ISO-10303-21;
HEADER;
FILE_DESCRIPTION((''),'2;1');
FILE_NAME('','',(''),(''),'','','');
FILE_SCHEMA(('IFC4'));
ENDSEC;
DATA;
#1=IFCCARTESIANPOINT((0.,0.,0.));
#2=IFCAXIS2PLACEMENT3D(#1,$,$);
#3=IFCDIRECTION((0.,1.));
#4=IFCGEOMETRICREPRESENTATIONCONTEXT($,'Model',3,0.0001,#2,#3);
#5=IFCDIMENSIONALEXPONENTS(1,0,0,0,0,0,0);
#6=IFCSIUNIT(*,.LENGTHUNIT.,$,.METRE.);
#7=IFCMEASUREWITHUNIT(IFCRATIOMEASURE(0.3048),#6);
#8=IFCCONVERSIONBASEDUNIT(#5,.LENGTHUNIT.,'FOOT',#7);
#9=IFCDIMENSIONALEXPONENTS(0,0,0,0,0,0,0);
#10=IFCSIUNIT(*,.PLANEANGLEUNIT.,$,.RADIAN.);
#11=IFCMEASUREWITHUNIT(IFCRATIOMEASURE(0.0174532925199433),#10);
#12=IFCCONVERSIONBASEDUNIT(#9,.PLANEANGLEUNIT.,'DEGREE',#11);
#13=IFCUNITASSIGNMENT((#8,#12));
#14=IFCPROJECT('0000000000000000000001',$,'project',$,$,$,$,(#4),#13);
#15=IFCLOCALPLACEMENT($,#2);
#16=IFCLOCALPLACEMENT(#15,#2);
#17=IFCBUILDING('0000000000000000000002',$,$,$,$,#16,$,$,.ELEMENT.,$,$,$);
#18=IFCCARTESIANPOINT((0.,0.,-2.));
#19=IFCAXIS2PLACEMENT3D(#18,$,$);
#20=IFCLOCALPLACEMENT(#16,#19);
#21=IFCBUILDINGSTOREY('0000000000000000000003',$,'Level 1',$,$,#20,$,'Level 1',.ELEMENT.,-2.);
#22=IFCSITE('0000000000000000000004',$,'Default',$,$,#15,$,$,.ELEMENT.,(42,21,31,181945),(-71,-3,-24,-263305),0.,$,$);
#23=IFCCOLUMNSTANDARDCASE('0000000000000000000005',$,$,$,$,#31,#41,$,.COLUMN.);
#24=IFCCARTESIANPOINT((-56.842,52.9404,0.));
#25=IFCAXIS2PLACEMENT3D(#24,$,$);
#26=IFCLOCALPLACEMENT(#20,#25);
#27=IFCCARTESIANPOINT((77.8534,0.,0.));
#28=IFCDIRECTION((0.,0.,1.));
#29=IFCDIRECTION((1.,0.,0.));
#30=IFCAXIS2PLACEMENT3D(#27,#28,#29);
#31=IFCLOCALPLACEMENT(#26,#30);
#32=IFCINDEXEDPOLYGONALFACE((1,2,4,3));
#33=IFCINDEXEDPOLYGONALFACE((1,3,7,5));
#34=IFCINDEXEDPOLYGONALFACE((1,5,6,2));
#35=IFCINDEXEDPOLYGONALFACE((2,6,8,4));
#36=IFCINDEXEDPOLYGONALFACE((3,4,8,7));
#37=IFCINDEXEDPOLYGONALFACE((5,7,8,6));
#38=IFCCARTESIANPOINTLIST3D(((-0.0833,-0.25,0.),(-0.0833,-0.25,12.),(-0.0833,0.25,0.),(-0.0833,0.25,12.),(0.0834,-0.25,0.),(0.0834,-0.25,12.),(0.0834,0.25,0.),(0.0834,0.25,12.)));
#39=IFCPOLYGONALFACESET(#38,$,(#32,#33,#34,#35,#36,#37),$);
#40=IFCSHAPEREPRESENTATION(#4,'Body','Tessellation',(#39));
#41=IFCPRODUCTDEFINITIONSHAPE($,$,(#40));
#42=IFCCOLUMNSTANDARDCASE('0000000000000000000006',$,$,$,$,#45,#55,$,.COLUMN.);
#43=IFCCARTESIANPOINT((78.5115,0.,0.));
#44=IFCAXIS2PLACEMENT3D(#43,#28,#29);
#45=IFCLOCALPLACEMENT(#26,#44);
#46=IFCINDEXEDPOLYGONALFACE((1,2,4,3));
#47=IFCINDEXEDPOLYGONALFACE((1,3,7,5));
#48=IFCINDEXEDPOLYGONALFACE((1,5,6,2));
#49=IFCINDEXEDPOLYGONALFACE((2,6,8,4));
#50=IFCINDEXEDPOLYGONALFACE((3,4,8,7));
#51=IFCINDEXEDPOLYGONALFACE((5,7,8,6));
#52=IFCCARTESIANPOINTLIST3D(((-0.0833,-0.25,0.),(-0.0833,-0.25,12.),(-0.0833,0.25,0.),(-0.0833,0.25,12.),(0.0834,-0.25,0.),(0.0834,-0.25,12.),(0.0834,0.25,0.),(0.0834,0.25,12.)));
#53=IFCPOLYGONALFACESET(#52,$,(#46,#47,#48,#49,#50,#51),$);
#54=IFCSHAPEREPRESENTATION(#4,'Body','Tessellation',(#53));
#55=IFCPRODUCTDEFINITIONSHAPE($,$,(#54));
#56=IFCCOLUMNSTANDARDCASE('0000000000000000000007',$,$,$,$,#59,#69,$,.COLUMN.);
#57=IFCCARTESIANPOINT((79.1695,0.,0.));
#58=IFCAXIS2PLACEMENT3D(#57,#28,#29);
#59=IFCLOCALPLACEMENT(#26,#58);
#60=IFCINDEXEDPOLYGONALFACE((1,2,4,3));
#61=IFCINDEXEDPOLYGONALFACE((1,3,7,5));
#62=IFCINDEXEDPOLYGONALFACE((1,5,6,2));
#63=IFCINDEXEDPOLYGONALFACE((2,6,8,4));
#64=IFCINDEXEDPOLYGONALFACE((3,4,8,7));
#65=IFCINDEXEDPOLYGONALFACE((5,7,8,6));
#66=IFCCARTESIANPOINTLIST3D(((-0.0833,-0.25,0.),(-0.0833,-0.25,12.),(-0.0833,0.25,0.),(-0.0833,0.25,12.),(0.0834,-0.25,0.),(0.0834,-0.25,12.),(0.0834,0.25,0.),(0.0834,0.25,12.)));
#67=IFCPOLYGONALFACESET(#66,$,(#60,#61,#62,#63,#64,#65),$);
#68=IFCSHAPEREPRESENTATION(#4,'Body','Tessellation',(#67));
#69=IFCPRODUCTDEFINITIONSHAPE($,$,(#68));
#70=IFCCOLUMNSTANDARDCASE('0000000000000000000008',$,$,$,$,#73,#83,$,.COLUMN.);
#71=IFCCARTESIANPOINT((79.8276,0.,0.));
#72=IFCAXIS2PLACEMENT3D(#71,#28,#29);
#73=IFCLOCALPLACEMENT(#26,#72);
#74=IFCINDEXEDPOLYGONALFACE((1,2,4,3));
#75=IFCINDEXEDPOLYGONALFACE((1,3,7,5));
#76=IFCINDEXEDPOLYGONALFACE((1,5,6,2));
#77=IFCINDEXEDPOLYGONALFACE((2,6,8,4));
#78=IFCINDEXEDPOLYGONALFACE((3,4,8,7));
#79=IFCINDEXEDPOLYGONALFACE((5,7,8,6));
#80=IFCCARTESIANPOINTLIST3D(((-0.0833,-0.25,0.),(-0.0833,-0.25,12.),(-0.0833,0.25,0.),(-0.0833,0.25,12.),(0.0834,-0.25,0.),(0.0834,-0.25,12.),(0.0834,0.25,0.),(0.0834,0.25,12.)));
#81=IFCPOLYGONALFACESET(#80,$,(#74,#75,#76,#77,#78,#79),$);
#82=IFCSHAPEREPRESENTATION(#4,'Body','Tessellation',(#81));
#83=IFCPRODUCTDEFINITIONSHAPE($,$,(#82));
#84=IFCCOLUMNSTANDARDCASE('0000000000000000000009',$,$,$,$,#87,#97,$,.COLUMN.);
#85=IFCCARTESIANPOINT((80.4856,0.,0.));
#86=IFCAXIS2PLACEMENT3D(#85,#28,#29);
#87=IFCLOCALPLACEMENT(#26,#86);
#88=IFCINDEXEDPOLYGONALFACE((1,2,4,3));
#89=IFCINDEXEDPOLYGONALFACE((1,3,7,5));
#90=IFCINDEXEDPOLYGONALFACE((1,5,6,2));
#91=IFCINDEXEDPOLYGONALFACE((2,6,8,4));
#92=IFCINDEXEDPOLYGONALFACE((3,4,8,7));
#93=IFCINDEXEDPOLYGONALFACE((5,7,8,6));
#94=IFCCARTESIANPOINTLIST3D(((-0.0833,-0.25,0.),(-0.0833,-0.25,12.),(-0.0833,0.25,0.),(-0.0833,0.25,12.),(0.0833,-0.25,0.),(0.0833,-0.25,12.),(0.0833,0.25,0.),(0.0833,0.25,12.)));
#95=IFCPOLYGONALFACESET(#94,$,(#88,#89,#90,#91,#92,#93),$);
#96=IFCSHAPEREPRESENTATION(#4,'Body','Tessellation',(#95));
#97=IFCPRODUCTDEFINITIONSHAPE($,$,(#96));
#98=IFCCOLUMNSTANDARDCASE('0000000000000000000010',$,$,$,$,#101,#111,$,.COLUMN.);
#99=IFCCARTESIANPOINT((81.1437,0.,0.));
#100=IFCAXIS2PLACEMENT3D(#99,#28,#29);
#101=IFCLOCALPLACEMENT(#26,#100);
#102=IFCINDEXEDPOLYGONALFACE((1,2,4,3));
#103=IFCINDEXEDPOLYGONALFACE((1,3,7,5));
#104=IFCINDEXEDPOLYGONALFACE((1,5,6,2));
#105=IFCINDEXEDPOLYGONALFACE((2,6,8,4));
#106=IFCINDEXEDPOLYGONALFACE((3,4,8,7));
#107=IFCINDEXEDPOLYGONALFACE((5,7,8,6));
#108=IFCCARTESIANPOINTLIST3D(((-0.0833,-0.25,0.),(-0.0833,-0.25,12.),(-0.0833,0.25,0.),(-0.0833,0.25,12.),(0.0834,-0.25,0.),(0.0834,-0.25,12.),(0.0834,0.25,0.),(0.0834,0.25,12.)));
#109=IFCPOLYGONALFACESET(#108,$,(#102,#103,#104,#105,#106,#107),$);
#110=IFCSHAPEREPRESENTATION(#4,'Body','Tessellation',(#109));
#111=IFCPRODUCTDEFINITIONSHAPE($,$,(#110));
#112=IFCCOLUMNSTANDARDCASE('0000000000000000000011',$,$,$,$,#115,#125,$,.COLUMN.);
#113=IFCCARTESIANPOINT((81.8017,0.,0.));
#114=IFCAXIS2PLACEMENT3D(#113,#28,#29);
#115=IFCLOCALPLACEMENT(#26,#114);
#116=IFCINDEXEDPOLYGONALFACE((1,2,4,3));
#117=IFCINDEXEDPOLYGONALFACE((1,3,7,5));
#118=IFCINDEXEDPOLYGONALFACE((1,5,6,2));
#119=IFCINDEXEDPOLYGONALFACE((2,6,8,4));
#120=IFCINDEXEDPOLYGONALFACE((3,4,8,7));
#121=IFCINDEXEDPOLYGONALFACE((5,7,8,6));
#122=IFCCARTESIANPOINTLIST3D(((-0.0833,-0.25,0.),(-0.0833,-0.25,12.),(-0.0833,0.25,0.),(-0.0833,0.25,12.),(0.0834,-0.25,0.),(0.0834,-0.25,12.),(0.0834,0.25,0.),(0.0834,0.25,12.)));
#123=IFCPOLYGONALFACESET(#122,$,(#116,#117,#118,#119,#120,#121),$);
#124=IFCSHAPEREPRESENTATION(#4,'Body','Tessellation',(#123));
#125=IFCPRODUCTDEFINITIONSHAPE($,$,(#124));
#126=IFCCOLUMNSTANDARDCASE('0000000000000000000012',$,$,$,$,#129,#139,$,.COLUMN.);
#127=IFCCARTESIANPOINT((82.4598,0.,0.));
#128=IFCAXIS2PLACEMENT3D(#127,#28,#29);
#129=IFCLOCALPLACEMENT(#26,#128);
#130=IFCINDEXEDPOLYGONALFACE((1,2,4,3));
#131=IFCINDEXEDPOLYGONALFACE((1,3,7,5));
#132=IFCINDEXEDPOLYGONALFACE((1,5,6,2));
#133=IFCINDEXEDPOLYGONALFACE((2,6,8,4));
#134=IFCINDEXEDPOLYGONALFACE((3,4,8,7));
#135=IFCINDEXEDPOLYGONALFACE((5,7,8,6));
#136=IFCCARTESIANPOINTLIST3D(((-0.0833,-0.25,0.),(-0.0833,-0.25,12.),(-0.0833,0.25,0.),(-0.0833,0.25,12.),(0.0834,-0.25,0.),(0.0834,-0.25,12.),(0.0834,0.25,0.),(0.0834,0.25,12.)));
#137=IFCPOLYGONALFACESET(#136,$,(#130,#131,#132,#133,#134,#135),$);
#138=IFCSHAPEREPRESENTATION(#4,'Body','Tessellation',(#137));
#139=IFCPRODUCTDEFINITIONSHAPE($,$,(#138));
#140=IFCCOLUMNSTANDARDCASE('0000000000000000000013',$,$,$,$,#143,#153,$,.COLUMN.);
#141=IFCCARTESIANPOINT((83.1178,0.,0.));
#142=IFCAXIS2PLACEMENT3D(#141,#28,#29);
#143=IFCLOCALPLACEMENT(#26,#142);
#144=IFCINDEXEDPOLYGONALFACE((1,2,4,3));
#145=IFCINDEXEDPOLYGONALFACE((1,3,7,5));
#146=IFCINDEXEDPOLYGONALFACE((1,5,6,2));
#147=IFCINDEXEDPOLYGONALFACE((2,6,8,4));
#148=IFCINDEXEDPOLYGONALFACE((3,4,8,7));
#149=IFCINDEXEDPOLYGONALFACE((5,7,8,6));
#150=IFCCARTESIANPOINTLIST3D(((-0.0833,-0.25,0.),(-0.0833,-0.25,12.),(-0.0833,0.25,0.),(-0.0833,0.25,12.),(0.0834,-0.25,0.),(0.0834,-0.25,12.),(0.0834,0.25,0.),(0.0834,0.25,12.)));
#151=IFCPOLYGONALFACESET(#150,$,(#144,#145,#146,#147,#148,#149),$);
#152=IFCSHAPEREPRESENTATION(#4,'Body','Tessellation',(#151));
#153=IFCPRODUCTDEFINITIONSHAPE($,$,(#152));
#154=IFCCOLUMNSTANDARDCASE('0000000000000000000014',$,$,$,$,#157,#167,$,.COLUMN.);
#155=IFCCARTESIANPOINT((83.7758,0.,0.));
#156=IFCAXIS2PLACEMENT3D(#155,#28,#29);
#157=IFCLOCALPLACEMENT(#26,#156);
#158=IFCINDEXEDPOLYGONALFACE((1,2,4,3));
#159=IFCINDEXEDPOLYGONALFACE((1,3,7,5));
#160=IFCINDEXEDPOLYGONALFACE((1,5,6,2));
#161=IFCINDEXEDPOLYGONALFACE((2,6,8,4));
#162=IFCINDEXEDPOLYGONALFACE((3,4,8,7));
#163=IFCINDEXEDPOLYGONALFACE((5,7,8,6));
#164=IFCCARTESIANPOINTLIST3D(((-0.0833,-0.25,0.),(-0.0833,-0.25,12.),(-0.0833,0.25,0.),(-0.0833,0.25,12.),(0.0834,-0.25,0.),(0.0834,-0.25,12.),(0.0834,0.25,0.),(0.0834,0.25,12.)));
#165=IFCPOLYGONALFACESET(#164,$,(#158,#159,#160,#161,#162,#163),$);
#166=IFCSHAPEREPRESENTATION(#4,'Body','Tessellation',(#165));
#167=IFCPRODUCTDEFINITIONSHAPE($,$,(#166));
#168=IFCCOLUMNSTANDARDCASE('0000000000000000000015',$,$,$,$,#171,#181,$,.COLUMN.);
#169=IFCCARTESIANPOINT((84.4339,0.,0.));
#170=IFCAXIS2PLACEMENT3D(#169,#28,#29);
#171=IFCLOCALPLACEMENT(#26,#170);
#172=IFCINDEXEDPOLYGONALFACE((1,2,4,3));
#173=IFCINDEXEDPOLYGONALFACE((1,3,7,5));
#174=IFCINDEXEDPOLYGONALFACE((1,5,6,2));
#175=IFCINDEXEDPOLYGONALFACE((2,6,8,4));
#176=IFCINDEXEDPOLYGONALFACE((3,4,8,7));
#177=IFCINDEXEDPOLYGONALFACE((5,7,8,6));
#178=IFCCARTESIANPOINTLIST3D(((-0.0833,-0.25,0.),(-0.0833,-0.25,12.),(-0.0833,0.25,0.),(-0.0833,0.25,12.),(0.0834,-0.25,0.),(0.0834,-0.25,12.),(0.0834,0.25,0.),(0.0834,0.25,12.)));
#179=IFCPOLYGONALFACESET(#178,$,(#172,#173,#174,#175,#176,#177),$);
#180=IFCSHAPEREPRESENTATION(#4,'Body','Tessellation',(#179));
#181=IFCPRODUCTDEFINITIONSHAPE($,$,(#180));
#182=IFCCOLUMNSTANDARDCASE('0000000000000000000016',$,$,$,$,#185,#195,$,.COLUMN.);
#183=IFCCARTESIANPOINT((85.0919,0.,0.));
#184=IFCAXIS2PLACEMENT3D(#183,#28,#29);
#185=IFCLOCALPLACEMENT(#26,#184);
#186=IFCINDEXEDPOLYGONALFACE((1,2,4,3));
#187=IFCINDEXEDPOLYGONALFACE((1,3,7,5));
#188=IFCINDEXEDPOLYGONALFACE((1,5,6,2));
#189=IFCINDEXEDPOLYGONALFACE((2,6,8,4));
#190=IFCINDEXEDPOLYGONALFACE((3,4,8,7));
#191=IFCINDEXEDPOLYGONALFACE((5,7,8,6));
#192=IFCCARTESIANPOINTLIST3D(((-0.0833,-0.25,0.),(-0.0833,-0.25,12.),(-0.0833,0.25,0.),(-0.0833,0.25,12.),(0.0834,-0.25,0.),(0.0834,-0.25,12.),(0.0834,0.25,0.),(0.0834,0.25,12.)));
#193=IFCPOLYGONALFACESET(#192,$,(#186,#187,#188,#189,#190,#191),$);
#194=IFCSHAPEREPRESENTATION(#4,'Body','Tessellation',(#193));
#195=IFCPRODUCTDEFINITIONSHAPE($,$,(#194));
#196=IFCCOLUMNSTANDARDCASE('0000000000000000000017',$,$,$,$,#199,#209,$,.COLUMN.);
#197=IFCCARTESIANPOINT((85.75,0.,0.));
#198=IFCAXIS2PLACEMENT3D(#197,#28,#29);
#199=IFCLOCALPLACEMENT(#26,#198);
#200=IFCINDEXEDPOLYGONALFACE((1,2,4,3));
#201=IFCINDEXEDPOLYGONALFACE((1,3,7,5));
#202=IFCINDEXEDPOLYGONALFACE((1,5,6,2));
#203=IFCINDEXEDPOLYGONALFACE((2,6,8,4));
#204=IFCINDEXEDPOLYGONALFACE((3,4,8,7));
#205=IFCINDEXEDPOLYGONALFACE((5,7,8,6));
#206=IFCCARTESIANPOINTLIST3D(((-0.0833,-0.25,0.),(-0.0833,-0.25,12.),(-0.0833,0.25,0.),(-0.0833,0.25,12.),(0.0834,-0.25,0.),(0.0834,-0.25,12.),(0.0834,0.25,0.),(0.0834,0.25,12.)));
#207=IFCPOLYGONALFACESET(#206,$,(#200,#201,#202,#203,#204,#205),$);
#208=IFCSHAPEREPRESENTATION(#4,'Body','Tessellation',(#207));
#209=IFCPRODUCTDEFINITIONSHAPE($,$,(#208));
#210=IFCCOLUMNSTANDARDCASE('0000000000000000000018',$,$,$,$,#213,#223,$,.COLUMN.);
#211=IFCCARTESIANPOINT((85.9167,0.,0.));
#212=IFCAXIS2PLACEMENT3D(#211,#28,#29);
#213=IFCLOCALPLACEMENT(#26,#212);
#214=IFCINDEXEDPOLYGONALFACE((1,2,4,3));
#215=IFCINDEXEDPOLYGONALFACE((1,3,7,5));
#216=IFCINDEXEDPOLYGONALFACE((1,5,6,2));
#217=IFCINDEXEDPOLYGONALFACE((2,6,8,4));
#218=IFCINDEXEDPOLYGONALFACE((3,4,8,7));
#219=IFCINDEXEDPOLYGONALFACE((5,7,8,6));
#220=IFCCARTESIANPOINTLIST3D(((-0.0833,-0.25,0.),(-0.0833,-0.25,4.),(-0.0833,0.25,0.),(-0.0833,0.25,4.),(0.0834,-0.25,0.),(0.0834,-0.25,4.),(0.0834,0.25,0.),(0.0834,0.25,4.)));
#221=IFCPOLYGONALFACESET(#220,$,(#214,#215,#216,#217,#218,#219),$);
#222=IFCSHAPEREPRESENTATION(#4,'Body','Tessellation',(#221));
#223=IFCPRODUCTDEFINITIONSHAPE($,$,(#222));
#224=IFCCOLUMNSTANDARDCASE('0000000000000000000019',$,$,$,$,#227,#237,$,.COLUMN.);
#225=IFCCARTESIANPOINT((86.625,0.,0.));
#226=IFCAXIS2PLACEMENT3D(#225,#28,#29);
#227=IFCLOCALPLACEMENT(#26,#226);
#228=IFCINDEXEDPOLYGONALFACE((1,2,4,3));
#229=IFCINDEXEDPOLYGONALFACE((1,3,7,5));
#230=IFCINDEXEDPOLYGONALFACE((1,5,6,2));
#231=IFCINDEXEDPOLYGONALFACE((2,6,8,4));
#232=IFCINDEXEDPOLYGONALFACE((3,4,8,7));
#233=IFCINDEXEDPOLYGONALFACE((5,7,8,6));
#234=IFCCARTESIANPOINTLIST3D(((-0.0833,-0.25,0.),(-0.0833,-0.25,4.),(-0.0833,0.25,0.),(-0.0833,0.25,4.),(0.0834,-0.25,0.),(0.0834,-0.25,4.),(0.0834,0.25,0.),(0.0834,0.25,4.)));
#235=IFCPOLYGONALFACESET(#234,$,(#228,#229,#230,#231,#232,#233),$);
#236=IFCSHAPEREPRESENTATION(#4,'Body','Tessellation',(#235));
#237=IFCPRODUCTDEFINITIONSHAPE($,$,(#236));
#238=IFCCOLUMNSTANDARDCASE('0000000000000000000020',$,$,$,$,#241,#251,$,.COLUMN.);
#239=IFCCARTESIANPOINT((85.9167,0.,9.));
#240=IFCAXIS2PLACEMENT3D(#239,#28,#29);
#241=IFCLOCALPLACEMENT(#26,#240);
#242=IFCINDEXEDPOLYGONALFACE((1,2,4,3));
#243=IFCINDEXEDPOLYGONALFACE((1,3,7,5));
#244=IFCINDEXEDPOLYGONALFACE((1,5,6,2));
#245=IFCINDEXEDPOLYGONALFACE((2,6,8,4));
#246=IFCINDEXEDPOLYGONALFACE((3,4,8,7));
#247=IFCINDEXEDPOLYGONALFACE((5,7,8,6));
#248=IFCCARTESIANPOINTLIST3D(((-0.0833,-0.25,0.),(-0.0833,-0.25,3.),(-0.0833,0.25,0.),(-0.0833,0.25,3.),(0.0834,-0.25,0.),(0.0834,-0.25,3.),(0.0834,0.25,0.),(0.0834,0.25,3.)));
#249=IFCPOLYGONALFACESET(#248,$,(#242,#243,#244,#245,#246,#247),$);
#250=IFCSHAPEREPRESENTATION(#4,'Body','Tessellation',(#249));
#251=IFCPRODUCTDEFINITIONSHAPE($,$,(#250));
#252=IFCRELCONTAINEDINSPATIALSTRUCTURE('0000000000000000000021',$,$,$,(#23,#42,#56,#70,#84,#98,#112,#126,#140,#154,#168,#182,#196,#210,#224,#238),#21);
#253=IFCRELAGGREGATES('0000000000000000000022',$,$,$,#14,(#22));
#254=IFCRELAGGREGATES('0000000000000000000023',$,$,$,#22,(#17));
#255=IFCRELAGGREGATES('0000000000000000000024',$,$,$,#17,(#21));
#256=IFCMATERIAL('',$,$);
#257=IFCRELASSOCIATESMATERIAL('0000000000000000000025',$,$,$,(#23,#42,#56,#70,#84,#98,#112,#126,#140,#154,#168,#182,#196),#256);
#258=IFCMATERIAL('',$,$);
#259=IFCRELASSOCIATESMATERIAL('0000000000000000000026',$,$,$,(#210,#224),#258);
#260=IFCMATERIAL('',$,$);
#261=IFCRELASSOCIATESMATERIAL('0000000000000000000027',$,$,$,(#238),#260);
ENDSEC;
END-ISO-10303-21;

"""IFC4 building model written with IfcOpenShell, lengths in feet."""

from ifc_helpers import new_model, entity, si_unit, converted_unit, direction, frame, origin, place, context, project, spatial, rectangle, extrude, material, element, save


model = new_model("IFC4")

# Units and contexts
model_context = context("Model", 3, precision=0.0001, world=origin(), true_north=direction((0.0, 1.0)))
ifc_project = project(units=[converted_unit("LENGTHUNIT", "FOOT", entity("IfcRatioMeasure", 0.3048), si_unit("LENGTHUNIT", "METRE"), dimensions=[1, 0, 0, 0, 0, 0, 0]), converted_unit("PLANEANGLEUNIT", "DEGREE", entity("IfcRatioMeasure", 0.0174532925199433), si_unit("PLANEANGLEUNIT", "RADIAN"), dimensions=[0, 0, 0, 0, 0, 0, 0])], contexts=[model_context])

# Site, building, storey
site_placement = place(None, origin())
site = spatial("IfcSite", under=ifc_project, at=site_placement, Name="Default", CompositionType="ELEMENT", RefLatitude=(42, 21, 31, 181945), RefLongitude=(-71, -3, -24, -263305), RefElevation=0.0)
building_placement = place(site_placement, origin())
building = spatial("IfcBuilding", under=site, at=building_placement, CompositionType="ELEMENT")
storey_placement = place(building_placement, frame((0.0, 0.0, -2.0)))
storey = spatial("IfcBuildingStorey", under=building, at=storey_placement, Name="Level 1", LongName="Level 1", CompositionType="ELEMENT", Elevation=-2.0)

# Columns
ifc_material_1 = material(Name="")
placement = place(storey_placement, frame((-56.842, 52.9404, 0.0)))
for number, where, z_axis, x_axis in (
    (1, (77.8534, 0.0, 0.0), (0.0, 0.0, 1.0), (1.0, 0.0, 0.0)),
    (2, (78.5115, 0.0, 0.0), (0.0, 0.0, 1.0), (1.0, 0.0, 0.0)),
    (3, (79.1695, 0.0, 0.0), (0.0, 0.0, 1.0), (1.0, 0.0, 0.0)),
    (4, (79.8276, 0.0, 0.0), (0.0, 0.0, 1.0), (1.0, 0.0, 0.0)),
    (5, (80.4856, 0.0, 0.0), (0.0, 0.0, 1.0), (1.0, 0.0, 0.0)),
    (6, (81.1437, 0.0, 0.0), (0.0, 0.0, 1.0), (1.0, 0.0, 0.0)),
    (7, (81.8017, 0.0, 0.0), (0.0, 0.0, 1.0), (1.0, 0.0, 0.0)),
    (8, (82.4598, 0.0, 0.0), (0.0, 0.0, 1.0), (1.0, 0.0, 0.0)),
    (9, (83.1178, 0.0, 0.0), (0.0, 0.0, 1.0), (1.0, 0.0, 0.0)),
    (10, (83.7758, 0.0, 0.0), (0.0, 0.0, 1.0), (1.0, 0.0, 0.0)),
    (11, (84.4339, 0.0, 0.0), (0.0, 0.0, 1.0), (1.0, 0.0, 0.0)),
    (12, (85.0919, 0.0, 0.0), (0.0, 0.0, 1.0), (1.0, 0.0, 0.0)),
    (13, (85.75, 0.0, 0.0), (0.0, 0.0, 1.0), (1.0, 0.0, 0.0)),
):
    element("IfcColumnStandardCase", number, at=place(placement, frame(where, z_axis=z_axis, x_axis=x_axis)), inside=storey, material=ifc_material_1, PredefinedType="COLUMN", context=model_context, shape_type="SweptSolid", body=[
        extrude(rectangle(XDim=0.1667, YDim=0.5), origin(), (0.0, 0.0, 1.0), 12.0),
    ])
ifc_material_2 = material(Name="")
for number, where, z_axis, x_axis in (
    (14, (85.9167, 0.0, 0.0), (0.0, 0.0, 1.0), (1.0, 0.0, 0.0)),
    (15, (86.625, 0.0, 0.0), (0.0, 0.0, 1.0), (1.0, 0.0, 0.0)),
):
    element("IfcColumnStandardCase", number, at=place(placement, frame(where, z_axis=z_axis, x_axis=x_axis)), inside=storey, material=ifc_material_2, PredefinedType="COLUMN", context=model_context, shape_type="SweptSolid", body=[
        extrude(rectangle(XDim=0.1667, YDim=0.5), origin(), (0.0, 0.0, 1.0), 4.0),
    ])
ifc_material_3 = material(Name="")
for number, where, z_axis, x_axis in (
    (16, (85.9167, 0.0, 9.0), (0.0, 0.0, 1.0), (1.0, 0.0, 0.0)),
):
    element("IfcColumnStandardCase", number, at=place(placement, frame(where, z_axis=z_axis, x_axis=x_axis)), inside=storey, material=ifc_material_3, PredefinedType="COLUMN", context=model_context, shape_type="SweptSolid", body=[
        extrude(rectangle(XDim=0.1667, YDim=0.5), origin(), (0.0, 0.0, 1.0), 3.0),
    ])

save(model, "model.ifc")
